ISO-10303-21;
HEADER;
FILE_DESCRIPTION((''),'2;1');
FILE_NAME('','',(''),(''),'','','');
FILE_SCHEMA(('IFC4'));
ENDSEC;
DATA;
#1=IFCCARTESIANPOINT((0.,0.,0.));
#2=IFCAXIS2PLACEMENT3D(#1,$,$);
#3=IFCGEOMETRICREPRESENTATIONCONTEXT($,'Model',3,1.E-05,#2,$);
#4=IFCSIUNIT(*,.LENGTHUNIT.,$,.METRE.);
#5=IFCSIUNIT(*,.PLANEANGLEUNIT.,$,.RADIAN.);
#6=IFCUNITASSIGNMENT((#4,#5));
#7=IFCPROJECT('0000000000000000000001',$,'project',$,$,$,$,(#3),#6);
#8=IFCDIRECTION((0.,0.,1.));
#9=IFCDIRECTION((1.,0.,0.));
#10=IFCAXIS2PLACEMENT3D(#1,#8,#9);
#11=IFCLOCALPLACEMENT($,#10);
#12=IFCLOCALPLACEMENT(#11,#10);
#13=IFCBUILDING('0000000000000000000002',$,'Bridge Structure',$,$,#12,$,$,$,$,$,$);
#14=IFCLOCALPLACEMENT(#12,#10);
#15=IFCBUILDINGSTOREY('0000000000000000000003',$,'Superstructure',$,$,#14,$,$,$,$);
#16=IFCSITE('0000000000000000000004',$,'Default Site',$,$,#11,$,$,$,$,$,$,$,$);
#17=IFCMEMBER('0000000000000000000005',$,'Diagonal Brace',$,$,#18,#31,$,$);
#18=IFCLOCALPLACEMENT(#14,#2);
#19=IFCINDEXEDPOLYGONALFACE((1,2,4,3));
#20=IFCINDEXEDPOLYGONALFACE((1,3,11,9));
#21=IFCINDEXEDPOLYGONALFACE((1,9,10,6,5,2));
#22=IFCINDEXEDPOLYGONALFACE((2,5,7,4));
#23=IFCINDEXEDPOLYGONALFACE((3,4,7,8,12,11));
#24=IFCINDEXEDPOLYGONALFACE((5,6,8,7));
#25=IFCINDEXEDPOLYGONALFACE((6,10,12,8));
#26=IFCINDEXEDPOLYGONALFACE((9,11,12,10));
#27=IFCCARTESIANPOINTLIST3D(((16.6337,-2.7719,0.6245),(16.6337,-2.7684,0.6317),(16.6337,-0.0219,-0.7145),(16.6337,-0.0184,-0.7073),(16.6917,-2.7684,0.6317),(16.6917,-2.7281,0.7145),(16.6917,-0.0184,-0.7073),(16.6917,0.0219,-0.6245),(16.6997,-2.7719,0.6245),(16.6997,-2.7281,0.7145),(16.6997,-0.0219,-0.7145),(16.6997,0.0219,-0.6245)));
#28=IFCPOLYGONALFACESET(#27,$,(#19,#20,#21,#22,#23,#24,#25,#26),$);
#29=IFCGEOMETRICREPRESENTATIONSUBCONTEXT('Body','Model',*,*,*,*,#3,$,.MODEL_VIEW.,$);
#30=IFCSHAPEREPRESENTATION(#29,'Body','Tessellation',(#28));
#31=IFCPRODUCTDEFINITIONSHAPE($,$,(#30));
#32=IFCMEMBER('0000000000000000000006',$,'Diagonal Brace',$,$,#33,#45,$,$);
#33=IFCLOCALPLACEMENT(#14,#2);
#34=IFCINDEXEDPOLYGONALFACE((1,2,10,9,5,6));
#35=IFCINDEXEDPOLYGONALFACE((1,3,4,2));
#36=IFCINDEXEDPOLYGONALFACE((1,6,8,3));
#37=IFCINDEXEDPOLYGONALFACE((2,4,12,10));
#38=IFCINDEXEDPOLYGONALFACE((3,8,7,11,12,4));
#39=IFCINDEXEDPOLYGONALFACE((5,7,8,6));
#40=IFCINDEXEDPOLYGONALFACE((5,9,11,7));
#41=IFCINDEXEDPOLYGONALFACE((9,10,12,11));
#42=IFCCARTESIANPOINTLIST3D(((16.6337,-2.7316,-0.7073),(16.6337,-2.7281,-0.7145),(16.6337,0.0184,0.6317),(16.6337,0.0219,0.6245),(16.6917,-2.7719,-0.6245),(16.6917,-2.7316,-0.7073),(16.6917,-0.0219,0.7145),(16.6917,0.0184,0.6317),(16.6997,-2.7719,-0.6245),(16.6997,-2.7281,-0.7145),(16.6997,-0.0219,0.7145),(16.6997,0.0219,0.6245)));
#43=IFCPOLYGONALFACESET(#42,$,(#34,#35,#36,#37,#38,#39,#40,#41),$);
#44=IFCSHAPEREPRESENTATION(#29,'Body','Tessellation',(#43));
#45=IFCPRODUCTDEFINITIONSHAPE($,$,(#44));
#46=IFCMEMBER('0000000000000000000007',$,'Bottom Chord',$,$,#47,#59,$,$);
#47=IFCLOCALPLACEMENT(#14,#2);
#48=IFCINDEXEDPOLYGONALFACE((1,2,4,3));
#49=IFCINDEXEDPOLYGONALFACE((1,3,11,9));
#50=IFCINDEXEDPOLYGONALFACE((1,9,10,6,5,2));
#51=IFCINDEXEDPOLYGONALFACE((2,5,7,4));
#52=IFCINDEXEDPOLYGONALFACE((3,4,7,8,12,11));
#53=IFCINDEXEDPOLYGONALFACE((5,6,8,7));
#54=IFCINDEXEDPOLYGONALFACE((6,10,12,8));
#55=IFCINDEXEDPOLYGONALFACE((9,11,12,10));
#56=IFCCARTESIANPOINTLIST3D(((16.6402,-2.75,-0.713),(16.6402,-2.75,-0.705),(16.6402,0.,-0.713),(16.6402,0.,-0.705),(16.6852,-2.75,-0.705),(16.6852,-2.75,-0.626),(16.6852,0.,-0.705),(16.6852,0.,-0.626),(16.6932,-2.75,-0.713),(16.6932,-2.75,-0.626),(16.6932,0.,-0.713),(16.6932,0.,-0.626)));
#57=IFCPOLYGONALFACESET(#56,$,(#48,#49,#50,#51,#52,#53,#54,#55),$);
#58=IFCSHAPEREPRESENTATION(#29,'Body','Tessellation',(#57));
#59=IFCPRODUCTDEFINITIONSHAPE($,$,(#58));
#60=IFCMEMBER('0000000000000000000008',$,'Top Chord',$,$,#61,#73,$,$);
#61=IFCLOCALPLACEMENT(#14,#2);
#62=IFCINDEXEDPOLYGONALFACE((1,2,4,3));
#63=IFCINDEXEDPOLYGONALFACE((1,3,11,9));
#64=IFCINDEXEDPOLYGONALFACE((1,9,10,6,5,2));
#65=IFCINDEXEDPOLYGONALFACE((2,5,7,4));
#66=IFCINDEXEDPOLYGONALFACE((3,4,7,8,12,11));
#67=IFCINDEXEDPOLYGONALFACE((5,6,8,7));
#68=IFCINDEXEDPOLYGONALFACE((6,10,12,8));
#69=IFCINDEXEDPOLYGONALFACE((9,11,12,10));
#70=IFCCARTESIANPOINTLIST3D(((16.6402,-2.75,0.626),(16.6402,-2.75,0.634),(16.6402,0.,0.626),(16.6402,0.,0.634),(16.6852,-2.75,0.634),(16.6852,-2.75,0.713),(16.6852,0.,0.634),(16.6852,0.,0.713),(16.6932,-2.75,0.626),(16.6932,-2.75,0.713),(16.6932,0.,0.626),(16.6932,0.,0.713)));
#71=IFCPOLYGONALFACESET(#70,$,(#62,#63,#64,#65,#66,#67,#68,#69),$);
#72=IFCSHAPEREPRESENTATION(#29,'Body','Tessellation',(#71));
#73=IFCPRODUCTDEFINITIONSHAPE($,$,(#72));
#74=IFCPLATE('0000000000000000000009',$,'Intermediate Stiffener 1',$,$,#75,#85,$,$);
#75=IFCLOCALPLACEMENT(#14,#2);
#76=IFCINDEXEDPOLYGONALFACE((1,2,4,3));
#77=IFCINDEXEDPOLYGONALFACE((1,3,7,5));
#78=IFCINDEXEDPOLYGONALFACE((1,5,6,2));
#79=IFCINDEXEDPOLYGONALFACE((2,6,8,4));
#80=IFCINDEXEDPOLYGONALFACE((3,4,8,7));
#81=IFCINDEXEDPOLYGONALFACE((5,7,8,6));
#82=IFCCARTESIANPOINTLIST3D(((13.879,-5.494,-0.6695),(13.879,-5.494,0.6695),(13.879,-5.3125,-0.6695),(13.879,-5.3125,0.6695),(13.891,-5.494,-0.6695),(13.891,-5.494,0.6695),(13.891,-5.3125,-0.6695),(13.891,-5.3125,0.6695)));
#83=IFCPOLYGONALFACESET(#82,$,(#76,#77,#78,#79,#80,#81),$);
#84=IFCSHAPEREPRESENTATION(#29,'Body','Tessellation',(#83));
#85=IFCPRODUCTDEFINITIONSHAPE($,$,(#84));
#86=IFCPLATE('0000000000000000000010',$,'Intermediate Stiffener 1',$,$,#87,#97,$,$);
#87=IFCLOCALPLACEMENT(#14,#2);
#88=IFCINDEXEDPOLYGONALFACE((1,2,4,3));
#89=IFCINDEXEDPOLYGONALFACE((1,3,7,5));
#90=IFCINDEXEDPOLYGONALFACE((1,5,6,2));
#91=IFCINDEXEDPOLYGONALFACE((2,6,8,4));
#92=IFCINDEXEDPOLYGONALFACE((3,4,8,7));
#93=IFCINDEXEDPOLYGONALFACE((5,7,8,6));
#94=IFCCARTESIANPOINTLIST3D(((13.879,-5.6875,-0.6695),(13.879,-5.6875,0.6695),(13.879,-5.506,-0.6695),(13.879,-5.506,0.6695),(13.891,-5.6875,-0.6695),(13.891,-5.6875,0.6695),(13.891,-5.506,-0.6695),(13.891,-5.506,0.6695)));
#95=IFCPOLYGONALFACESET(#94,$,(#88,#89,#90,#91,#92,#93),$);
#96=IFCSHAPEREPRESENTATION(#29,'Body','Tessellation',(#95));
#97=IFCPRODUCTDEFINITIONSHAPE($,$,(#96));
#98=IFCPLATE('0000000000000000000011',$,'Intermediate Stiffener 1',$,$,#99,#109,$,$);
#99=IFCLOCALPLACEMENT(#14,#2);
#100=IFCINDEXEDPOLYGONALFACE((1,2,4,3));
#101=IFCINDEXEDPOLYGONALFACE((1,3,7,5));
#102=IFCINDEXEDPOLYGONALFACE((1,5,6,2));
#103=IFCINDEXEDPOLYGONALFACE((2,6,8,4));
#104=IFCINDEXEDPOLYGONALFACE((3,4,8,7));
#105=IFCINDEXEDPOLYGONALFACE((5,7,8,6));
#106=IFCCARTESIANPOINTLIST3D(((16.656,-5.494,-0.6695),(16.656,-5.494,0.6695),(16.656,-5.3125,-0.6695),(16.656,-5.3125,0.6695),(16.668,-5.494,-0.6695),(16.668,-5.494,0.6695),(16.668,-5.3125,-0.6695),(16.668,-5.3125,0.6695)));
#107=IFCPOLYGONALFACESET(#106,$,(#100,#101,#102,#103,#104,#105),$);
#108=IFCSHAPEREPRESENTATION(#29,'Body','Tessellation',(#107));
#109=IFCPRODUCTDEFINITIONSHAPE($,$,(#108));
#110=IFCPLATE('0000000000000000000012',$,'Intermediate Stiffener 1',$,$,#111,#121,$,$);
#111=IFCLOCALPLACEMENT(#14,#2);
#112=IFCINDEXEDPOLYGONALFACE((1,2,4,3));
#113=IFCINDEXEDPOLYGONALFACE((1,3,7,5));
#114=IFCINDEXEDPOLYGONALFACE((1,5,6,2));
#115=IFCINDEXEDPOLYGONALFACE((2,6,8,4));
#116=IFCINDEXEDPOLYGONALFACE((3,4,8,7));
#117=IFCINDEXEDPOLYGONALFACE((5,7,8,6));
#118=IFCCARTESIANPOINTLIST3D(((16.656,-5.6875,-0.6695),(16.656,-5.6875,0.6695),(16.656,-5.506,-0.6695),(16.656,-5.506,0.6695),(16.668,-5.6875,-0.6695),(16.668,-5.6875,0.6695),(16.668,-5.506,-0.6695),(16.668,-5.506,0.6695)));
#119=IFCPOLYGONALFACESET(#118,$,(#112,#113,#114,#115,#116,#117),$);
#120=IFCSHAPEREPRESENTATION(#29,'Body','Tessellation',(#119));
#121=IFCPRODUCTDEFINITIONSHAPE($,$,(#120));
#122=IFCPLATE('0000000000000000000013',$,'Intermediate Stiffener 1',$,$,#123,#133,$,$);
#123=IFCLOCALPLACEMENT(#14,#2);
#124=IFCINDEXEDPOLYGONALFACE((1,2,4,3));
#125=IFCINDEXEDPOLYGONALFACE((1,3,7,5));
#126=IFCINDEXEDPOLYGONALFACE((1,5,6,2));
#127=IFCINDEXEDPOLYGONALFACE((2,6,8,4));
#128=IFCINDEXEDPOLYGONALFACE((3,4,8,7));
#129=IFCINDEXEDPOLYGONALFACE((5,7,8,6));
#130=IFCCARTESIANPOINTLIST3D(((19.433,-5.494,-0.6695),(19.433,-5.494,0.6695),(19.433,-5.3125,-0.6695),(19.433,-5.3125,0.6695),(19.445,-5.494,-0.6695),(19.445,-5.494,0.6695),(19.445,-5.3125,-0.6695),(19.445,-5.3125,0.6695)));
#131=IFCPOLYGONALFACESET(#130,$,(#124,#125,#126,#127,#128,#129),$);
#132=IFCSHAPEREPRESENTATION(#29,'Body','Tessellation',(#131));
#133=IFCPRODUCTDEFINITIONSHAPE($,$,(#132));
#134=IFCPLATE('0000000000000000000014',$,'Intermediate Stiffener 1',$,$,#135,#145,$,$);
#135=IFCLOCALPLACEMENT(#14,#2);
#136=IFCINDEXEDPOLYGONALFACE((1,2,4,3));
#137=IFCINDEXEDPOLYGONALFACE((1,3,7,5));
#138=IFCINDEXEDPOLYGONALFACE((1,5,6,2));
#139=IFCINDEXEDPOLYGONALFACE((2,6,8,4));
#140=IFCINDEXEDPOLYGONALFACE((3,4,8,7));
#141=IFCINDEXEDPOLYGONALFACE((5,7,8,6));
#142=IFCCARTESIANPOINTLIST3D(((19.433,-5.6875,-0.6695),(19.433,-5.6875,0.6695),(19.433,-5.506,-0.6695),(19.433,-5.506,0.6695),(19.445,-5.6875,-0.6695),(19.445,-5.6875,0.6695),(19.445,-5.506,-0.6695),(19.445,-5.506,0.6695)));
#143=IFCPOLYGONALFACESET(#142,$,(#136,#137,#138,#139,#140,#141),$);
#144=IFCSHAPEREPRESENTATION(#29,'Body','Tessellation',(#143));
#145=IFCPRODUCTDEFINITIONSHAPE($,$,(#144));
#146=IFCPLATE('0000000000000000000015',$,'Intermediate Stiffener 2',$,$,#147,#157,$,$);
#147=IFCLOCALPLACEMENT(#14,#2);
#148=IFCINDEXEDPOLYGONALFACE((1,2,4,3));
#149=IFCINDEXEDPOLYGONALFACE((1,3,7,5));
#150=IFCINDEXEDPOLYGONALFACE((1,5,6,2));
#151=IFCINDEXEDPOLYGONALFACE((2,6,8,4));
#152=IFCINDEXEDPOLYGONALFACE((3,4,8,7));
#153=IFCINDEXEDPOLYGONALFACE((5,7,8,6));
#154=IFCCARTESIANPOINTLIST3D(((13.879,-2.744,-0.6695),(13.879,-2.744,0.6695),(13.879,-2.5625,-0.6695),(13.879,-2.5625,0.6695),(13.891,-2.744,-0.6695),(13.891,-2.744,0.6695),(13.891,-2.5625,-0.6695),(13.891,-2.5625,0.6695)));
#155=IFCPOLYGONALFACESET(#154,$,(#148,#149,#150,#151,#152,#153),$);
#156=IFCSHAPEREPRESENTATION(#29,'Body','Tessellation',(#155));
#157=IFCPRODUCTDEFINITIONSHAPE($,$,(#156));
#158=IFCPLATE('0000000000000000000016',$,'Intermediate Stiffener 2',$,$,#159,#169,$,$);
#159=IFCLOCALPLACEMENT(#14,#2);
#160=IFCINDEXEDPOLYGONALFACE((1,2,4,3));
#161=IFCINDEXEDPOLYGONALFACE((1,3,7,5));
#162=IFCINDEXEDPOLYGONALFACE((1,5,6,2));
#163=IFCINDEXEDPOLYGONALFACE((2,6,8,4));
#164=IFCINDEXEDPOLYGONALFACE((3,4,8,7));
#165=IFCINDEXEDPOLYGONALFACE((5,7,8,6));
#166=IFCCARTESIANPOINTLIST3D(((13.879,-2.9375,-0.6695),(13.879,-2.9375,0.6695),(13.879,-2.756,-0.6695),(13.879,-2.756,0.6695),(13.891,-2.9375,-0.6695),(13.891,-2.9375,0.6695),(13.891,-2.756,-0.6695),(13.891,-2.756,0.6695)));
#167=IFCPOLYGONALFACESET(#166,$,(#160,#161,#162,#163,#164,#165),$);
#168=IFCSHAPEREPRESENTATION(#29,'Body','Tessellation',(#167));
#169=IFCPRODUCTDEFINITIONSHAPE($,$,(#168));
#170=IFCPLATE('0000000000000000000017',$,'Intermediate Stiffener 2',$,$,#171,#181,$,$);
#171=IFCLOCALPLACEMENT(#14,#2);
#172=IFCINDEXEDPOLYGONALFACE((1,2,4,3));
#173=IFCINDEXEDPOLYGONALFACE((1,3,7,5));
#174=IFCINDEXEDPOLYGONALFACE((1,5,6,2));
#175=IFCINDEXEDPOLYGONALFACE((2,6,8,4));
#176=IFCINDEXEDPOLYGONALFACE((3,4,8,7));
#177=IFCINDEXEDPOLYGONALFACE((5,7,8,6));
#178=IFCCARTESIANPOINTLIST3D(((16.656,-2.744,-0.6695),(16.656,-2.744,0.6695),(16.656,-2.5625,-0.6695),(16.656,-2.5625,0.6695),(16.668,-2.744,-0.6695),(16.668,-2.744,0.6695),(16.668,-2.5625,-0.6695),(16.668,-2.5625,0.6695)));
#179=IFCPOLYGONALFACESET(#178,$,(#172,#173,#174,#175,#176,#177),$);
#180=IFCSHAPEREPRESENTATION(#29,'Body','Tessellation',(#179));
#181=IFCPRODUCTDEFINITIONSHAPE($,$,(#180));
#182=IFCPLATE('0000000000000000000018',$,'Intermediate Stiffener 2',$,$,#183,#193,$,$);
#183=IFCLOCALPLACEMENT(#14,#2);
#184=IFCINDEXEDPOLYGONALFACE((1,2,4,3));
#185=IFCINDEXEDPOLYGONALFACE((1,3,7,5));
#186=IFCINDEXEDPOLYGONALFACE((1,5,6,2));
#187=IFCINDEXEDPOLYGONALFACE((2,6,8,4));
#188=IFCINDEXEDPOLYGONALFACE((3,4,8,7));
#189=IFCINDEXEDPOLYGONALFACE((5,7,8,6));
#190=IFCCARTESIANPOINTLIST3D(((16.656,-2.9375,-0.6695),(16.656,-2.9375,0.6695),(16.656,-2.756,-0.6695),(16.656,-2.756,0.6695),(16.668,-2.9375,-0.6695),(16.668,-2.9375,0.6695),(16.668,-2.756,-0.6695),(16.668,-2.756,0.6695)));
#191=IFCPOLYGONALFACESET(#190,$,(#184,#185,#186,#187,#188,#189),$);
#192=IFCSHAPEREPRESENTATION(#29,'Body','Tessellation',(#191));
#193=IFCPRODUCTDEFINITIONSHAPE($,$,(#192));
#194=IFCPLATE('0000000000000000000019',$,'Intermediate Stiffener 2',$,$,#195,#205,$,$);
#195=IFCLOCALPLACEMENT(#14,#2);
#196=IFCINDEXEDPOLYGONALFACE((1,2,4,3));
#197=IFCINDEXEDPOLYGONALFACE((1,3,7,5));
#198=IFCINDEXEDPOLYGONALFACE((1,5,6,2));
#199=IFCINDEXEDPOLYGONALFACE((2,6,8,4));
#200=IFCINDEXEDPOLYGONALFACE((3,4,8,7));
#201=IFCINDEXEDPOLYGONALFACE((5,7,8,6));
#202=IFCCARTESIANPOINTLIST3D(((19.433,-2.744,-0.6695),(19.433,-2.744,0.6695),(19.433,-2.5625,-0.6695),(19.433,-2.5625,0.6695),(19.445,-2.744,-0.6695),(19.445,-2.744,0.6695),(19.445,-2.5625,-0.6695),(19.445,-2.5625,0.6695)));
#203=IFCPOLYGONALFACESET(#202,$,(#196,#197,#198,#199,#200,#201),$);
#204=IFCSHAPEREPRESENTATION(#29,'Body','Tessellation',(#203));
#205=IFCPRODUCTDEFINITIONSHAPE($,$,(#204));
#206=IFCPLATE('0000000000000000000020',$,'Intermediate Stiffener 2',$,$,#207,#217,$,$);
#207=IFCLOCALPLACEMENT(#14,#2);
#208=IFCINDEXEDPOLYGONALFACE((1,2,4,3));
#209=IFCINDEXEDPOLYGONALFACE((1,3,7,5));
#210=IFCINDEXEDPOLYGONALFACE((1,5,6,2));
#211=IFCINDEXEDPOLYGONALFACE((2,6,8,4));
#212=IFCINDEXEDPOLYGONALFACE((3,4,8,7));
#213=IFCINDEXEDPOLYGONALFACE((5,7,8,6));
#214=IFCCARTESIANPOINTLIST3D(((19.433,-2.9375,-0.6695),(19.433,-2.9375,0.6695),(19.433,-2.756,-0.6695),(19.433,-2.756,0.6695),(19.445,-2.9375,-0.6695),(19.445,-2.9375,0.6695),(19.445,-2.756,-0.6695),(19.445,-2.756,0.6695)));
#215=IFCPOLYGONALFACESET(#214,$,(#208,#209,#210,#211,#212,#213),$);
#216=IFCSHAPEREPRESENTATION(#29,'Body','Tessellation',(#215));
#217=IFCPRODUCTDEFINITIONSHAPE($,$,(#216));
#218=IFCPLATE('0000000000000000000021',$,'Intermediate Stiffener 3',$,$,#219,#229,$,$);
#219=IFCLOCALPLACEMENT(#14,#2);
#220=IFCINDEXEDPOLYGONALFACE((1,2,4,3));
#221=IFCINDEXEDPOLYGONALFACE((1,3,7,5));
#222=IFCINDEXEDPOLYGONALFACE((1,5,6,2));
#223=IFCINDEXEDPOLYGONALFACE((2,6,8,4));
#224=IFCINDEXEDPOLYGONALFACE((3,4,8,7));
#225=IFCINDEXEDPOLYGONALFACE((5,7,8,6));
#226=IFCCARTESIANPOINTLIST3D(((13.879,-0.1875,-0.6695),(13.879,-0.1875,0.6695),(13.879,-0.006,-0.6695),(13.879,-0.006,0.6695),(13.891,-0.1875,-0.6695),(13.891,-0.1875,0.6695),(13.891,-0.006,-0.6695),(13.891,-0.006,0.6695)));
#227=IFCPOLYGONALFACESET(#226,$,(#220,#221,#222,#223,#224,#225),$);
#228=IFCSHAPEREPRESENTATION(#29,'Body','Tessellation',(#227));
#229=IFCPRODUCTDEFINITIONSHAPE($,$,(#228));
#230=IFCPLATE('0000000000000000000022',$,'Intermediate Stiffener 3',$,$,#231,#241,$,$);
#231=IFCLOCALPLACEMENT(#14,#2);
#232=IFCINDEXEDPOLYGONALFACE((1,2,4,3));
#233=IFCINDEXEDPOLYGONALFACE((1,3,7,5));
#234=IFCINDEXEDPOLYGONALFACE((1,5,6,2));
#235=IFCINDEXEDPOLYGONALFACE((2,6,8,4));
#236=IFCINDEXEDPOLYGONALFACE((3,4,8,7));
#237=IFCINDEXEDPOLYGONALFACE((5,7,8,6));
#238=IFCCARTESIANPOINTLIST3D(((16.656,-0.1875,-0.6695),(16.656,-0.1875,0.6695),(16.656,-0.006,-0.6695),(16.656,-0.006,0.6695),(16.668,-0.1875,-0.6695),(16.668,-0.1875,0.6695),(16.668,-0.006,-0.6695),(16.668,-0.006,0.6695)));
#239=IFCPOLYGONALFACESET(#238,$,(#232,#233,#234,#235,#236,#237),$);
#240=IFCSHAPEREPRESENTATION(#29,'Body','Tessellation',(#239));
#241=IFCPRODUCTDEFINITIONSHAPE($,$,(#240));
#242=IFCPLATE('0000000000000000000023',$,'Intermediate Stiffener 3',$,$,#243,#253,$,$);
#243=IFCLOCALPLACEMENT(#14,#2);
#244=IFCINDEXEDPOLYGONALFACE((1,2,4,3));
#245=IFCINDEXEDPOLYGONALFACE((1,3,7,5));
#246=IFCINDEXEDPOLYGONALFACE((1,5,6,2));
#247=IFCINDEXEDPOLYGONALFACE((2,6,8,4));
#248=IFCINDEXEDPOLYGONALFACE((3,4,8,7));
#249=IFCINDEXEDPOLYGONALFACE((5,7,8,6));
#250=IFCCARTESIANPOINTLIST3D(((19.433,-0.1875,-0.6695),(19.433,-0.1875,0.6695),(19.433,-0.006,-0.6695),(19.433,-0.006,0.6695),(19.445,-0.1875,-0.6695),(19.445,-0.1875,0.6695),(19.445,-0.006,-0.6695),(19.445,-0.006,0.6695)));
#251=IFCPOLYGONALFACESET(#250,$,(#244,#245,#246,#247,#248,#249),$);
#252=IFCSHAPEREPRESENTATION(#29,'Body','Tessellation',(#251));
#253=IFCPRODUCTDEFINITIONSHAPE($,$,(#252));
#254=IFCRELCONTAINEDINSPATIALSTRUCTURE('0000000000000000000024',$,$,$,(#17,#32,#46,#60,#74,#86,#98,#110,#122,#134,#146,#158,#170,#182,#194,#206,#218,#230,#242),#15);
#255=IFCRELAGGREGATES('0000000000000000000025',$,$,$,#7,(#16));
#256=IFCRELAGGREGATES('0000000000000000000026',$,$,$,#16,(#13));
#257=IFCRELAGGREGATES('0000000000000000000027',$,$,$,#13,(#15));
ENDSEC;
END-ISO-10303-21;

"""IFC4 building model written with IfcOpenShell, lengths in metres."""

from ifc_helpers import new_model, si_unit, frame, origin, origin_with_axes, origin_2d_with_axis, place, context, subcontext, project, spatial, rectangle, l_section, extrude, element, save


model = new_model("IFC4")

# Units and contexts
model_context = context("Model", 3, precision=1e-05, world=origin())
body_context = subcontext(model_context, "Body", "Model", "MODEL_VIEW")
ifc_project = project(units=[si_unit("LENGTHUNIT", "METRE"), si_unit("PLANEANGLEUNIT", "RADIAN")], contexts=[model_context])

# Site, building, storey
site_placement = place(None, origin_with_axes())
site = spatial("IfcSite", under=ifc_project, at=site_placement, Name="Default Site")
building_placement = place(site_placement, origin_with_axes())
building = spatial("IfcBuilding", under=site, at=building_placement, Name="Bridge Structure")
storey_placement = place(building_placement, origin_with_axes())
storey = spatial("IfcBuildingStorey", under=building, at=storey_placement, Name="Superstructure")

# Members
for number, where, z_axis, x_axis, name in (
    (1, (16.6667, -2.75, 0.6695), (0.0, 0.899086, -0.437773), (-1.0, 0.0, 0.0), "Diagonal Brace"),
    (2, (16.6667, -2.75, -0.6695), (0.0, 0.899086, 0.437773), (-1.0, 0.0, 0.0), "Diagonal Brace"),
):
    element("IfcMember", number, at=place(storey_placement, frame(where, z_axis=z_axis, x_axis=x_axis)), inside=storey, Name=name, context=body_context, shape_type="SweptSolid", body=[
        extrude(l_section(Depth=0.1, Width=0.066, Thickness=0.008, at=origin_2d_with_axis()), origin_with_axes(), (0.0, 0.0, 1.0), 3.0587),
    ])
for number, where, z_axis, x_axis, name in (
    (3, (16.6667, -2.75, -0.6695), (0.0, 1.0, 0.0), (-1.0, 0.0, 0.0), "Bottom Chord"),
    (4, (16.6667, -2.75, 0.6695), (0.0, 1.0, 0.0), (-1.0, 0.0, 0.0), "Top Chord"),
):
    element("IfcMember", number, at=place(storey_placement, frame(where, z_axis=z_axis, x_axis=x_axis)), inside=storey, Name=name, context=body_context, shape_type="SweptSolid", body=[
        extrude(l_section(Depth=0.087, Width=0.053, Thickness=0.008, at=origin_2d_with_axis()), origin_with_axes(), (0.0, 0.0, 1.0), 2.75),
    ])

# Plates
for number, where, z_axis, x_axis, name in (
    (5, (13.885, -5.4032, -0.6695), (0.0, 0.0, 1.0), (1.0, 0.0, 0.0), "Intermediate Stiffener 1"),
    (6, (13.885, -5.5968, -0.6695), (0.0, 0.0, 1.0), (1.0, 0.0, 0.0), "Intermediate Stiffener 1"),
    (7, (16.662, -5.4032, -0.6695), (0.0, 0.0, 1.0), (1.0, 0.0, 0.0), "Intermediate Stiffener 1"),
    (8, (16.662, -5.5968, -0.6695), (0.0, 0.0, 1.0), (1.0, 0.0, 0.0), "Intermediate Stiffener 1"),
    (9, (19.439, -5.4032, -0.6695), (0.0, 0.0, 1.0), (1.0, 0.0, 0.0), "Intermediate Stiffener 1"),
    (10, (19.439, -5.5968, -0.6695), (0.0, 0.0, 1.0), (1.0, 0.0, 0.0), "Intermediate Stiffener 1"),
    (11, (13.885, -2.6532, -0.6695), (0.0, 0.0, 1.0), (1.0, 0.0, 0.0), "Intermediate Stiffener 2"),
    (12, (13.885, -2.8468, -0.6695), (0.0, 0.0, 1.0), (1.0, 0.0, 0.0), "Intermediate Stiffener 2"),
    (13, (16.662, -2.6532, -0.6695), (0.0, 0.0, 1.0), (1.0, 0.0, 0.0), "Intermediate Stiffener 2"),
    (14, (16.662, -2.8468, -0.6695), (0.0, 0.0, 1.0), (1.0, 0.0, 0.0), "Intermediate Stiffener 2"),
    (15, (19.439, -2.6532, -0.6695), (0.0, 0.0, 1.0), (1.0, 0.0, 0.0), "Intermediate Stiffener 2"),
    (16, (19.439, -2.8468, -0.6695), (0.0, 0.0, 1.0), (1.0, 0.0, 0.0), "Intermediate Stiffener 2"),
    (17, (13.885, -0.0968, -0.6695), (0.0, 0.0, 1.0), (1.0, 0.0, 0.0), "Intermediate Stiffener 3"),
    (18, (16.662, -0.0968, -0.6695), (0.0, 0.0, 1.0), (1.0, 0.0, 0.0), "Intermediate Stiffener 3"),
    (19, (19.439, -0.0968, -0.6695), (0.0, 0.0, 1.0), (1.0, 0.0, 0.0), "Intermediate Stiffener 3"),
):
    element("IfcPlate", number, at=place(storey_placement, frame(where, z_axis=z_axis, x_axis=x_axis)), inside=storey, Name=name, context=body_context, shape_type="SweptSolid", body=[
        extrude(rectangle(XDim=0.012, YDim=0.1815, at=origin_2d_with_axis()), origin_with_axes(), (0.0, 0.0, 1.0), 1.339),
    ])

save(model, "model.ifc")
